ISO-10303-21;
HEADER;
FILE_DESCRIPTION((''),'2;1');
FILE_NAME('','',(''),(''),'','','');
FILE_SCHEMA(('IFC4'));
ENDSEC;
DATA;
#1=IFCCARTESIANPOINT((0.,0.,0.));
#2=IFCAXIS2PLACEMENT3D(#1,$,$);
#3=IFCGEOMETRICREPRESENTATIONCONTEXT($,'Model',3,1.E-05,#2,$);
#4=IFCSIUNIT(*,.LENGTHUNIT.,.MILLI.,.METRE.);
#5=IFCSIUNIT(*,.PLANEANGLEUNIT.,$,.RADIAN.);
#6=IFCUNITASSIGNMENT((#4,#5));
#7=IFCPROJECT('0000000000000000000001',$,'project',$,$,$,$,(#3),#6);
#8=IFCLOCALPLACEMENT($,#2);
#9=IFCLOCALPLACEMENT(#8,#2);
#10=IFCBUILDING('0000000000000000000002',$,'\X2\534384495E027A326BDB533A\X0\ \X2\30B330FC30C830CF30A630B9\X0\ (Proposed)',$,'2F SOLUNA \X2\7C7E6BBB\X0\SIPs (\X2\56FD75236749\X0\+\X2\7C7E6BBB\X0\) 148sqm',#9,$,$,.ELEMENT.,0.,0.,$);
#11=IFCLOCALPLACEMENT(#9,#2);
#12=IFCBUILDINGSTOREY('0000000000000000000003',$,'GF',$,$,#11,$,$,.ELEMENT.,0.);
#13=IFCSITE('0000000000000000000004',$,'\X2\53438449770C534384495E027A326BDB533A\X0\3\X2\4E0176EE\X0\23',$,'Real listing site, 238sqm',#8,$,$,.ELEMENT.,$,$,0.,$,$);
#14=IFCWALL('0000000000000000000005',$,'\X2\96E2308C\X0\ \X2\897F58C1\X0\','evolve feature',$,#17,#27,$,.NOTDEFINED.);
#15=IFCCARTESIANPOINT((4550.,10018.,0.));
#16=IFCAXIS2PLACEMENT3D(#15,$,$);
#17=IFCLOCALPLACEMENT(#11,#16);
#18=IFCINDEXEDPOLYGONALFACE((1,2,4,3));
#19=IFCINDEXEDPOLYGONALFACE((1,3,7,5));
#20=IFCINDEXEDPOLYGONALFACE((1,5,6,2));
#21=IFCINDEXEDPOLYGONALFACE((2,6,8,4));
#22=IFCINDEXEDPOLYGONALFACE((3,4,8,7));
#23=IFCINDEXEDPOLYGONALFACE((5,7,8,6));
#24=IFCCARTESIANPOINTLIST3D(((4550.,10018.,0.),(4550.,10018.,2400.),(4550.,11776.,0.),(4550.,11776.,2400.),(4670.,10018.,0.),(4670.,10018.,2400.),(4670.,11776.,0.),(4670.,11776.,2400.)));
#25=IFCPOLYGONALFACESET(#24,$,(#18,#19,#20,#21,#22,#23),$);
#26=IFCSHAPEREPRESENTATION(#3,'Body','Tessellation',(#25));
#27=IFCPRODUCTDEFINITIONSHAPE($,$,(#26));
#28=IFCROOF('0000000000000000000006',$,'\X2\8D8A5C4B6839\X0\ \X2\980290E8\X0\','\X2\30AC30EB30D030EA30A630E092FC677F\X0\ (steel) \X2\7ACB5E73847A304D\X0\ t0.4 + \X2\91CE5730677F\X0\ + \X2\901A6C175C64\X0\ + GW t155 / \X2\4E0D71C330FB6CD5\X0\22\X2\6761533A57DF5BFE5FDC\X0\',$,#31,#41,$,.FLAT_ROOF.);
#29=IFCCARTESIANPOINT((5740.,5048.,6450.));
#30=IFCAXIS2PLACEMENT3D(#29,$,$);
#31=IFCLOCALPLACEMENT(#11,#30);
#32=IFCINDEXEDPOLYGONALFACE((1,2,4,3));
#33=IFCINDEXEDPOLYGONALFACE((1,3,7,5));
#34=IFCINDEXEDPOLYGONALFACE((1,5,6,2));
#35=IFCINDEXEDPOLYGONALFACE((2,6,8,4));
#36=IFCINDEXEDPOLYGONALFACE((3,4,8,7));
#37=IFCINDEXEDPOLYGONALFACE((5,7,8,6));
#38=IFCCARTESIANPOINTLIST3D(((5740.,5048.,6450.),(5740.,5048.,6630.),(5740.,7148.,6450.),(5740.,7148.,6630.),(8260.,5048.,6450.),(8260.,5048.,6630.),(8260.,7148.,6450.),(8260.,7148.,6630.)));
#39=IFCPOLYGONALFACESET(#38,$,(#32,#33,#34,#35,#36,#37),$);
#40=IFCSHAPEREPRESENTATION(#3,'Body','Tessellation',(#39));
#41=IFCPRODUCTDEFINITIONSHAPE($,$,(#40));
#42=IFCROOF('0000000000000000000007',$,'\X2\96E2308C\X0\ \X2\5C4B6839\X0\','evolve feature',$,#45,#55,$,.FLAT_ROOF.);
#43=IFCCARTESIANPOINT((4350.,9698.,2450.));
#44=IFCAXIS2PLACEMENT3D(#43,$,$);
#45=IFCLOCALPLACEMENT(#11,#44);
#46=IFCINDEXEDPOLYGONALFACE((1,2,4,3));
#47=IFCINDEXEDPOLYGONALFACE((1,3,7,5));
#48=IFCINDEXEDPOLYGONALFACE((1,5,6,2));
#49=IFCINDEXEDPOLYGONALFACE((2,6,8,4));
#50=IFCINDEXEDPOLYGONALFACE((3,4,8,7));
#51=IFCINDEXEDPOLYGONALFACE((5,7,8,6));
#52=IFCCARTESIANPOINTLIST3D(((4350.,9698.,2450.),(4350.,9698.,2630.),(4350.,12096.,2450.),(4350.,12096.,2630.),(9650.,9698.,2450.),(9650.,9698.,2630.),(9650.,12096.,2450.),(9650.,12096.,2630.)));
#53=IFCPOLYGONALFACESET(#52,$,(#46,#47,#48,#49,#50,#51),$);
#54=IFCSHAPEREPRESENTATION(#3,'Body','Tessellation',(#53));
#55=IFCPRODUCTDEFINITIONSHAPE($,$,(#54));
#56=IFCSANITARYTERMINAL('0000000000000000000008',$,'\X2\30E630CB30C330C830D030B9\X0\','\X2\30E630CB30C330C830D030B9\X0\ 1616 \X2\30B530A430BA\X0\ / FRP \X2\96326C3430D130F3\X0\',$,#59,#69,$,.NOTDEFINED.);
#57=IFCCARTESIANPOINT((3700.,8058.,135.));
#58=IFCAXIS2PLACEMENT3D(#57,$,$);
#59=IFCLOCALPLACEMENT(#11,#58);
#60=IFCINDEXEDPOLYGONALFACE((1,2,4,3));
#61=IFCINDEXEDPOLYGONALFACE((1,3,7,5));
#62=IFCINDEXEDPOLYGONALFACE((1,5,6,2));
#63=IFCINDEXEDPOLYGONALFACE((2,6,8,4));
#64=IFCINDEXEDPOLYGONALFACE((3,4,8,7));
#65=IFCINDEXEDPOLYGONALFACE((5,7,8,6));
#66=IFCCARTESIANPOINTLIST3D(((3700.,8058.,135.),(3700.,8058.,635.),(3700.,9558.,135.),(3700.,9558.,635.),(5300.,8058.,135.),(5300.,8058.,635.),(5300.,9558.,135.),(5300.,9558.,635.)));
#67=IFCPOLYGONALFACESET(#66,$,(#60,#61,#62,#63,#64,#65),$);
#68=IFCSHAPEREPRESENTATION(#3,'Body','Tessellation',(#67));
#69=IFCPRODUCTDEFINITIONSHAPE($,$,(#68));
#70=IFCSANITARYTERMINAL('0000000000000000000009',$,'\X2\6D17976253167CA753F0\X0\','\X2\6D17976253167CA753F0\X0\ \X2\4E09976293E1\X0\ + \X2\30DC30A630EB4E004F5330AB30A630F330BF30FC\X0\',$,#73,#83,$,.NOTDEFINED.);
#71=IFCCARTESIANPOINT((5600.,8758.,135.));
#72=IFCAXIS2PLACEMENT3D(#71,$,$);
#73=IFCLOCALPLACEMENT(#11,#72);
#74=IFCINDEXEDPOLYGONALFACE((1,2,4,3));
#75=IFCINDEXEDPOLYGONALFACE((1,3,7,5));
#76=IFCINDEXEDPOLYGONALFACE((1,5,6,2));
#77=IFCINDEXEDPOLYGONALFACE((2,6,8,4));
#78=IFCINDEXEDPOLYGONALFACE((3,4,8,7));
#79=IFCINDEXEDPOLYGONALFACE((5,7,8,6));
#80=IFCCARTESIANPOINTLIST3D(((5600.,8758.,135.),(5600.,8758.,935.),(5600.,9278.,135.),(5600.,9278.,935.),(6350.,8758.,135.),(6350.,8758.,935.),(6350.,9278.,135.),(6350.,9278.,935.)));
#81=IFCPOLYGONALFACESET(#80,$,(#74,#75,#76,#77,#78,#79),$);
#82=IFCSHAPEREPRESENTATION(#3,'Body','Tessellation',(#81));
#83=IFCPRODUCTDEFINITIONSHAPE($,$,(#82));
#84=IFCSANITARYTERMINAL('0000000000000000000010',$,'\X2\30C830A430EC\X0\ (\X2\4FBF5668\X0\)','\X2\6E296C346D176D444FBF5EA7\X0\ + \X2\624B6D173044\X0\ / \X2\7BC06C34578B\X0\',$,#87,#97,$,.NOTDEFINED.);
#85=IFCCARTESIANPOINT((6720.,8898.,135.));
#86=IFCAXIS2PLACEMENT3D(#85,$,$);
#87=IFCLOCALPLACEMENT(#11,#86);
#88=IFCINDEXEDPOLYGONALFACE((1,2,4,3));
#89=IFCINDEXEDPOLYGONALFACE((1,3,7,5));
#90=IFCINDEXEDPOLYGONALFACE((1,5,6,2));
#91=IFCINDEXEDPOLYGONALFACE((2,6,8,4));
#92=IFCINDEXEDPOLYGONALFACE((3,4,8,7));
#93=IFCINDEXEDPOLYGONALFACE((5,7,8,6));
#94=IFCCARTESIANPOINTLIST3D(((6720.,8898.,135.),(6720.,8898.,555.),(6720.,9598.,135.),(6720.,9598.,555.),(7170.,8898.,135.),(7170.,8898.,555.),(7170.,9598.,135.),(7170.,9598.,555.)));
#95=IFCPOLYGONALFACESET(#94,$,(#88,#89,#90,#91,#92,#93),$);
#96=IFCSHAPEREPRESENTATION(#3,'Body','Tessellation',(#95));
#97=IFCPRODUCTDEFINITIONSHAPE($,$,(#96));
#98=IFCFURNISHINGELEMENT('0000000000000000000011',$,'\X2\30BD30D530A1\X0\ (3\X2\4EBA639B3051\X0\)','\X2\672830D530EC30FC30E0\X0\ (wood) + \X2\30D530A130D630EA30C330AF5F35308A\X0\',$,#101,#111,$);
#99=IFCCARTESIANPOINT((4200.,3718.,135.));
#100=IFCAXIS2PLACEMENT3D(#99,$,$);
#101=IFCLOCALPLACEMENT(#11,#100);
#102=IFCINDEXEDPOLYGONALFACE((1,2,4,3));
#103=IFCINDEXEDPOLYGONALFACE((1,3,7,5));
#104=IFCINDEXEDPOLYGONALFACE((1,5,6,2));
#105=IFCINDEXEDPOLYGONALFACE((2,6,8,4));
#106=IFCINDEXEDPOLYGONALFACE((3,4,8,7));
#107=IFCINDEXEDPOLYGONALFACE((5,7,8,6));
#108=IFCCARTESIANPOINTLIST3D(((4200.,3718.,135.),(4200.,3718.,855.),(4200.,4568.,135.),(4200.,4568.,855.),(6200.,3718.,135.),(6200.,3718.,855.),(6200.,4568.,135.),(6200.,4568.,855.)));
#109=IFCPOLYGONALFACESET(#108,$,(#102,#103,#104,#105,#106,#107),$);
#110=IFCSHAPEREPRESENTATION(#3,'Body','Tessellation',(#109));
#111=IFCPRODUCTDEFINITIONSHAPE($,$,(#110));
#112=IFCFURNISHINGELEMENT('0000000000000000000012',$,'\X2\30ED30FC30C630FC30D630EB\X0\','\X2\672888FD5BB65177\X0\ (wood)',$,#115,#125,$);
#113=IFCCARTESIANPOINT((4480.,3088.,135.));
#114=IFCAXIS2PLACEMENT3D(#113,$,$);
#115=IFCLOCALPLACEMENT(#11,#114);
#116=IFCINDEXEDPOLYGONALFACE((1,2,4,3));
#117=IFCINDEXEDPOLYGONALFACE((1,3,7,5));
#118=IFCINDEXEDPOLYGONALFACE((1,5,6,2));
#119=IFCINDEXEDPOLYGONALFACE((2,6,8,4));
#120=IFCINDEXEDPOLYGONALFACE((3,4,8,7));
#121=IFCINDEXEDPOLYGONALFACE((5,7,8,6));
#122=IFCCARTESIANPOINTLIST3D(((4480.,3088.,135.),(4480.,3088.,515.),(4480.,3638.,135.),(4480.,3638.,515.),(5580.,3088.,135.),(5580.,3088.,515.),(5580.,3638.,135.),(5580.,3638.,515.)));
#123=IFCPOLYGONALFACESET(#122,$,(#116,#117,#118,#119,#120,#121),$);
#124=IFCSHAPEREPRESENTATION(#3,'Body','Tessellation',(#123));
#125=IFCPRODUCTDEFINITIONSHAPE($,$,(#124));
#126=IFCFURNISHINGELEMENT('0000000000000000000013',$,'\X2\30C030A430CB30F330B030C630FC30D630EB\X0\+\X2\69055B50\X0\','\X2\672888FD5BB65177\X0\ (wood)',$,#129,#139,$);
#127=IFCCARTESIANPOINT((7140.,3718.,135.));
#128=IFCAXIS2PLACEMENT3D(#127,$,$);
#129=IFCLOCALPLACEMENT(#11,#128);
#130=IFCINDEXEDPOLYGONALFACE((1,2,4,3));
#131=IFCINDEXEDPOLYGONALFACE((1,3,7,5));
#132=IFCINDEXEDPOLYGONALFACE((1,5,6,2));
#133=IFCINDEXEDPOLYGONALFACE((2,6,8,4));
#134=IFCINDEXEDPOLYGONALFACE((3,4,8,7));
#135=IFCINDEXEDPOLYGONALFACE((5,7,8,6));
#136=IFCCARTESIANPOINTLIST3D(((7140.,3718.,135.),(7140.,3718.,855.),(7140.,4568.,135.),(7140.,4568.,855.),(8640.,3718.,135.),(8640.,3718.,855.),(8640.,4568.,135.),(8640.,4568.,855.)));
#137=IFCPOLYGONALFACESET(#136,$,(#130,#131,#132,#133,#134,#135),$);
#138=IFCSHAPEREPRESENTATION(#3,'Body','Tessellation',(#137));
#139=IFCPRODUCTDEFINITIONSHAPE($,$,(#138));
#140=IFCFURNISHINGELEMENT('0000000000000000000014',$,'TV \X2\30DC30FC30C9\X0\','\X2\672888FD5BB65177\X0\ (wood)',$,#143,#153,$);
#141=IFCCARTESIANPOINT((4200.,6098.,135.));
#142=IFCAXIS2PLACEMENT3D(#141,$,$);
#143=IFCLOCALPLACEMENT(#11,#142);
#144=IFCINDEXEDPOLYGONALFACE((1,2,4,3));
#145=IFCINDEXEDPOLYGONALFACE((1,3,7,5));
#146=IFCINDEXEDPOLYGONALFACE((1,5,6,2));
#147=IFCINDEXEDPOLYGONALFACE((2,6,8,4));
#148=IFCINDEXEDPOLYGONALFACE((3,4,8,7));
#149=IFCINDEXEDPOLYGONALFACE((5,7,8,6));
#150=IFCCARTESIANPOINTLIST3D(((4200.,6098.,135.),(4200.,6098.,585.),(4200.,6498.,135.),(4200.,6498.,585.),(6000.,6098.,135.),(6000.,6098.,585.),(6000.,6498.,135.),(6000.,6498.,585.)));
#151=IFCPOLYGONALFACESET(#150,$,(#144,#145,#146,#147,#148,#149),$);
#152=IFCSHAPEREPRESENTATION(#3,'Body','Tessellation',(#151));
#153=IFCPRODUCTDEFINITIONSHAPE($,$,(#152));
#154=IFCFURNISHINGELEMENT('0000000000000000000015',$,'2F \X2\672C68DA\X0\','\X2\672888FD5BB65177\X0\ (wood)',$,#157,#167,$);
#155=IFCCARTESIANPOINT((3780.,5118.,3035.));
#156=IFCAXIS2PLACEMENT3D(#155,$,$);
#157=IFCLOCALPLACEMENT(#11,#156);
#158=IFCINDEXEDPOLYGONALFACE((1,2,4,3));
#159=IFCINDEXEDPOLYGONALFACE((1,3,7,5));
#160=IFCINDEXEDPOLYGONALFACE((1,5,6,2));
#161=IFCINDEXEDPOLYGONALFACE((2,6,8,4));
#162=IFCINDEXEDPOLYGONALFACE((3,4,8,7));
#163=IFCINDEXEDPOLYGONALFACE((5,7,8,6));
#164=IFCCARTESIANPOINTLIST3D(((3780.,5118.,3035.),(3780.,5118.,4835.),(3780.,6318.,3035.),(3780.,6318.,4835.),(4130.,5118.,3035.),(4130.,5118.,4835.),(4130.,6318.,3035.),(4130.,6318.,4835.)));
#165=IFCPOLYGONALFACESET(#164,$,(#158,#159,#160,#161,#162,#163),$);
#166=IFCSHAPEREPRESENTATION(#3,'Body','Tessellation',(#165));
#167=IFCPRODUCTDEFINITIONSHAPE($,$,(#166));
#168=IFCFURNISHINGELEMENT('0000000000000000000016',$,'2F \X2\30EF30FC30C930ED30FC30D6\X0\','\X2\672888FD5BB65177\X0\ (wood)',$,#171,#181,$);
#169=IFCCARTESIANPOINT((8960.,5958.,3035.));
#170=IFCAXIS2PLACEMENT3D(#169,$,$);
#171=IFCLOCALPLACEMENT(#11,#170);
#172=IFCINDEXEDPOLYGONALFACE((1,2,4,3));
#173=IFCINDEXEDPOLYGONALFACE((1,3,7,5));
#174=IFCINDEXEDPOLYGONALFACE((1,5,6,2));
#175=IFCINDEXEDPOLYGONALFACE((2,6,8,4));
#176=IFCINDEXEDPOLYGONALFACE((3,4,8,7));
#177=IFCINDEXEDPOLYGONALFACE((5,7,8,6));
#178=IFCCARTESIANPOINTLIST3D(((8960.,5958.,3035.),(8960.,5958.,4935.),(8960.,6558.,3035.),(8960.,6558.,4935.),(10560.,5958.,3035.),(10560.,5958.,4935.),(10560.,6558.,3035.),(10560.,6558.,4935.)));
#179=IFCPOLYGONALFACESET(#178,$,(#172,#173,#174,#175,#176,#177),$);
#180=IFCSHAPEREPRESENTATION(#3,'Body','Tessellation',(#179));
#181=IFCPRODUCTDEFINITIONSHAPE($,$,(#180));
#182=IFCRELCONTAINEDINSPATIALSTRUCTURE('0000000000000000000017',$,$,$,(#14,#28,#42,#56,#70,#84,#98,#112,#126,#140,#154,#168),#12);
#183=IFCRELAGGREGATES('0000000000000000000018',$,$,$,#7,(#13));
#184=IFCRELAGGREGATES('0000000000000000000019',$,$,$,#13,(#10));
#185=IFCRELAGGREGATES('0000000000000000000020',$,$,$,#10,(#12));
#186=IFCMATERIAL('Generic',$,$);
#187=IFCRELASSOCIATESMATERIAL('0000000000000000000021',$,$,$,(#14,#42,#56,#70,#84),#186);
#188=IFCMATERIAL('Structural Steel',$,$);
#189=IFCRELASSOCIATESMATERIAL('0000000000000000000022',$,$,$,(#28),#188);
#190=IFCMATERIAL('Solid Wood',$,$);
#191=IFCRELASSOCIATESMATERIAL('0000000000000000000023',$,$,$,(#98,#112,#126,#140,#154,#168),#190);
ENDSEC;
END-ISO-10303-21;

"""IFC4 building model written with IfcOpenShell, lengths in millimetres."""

from ifc_helpers import new_model, si_unit, frame, frame_2d, origin, place, context, project, spatial, rectangle, extrude, material, element, save


model = new_model("IFC4")

# Units and contexts
model_context = context("Model", 3, precision=1e-05, world=origin())
ifc_project = project(units=[si_unit("LENGTHUNIT", "METRE", prefix="MILLI"), si_unit("PLANEANGLEUNIT", "RADIAN")], contexts=[model_context])

# Site, building, storey
site_placement = place(None, origin())
site = spatial("IfcSite", under=ifc_project, at=site_placement, Name="千葉県千葉市稲毛区3丁目23", ObjectType="Real listing site, 238sqm", CompositionType="ELEMENT", RefElevation=0.0)
building_placement = place(site_placement, origin())
building = spatial("IfcBuilding", under=site, at=building_placement, Name="千葉市稲毛区 コートハウス (Proposed)", ObjectType="2F SOLUNA 籾殻SIPs (国産杉+籾殻) 148sqm", CompositionType="ELEMENT", ElevationOfRefHeight=0.0, ElevationOfTerrain=0.0)
storey_placement = place(building_placement, origin())
storey = spatial("IfcBuildingStorey", under=building, at=storey_placement, Name="GF", CompositionType="ELEMENT", Elevation=0.0)

# Shared definitions
ifc_material_1 = material(Name="Generic")

# Shared definitions
ifc_material_2 = material(Name="Solid Wood")

# Wall
wall_1_placement = place(storey_placement, frame((4550.0, 10018.0, 0.0)))
element("IfcWall", 1, at=wall_1_placement, inside=storey, material=ifc_material_1, Name="離れ 西壁", Description="evolve feature", PredefinedType="NOTDEFINED", context=model_context, shape_type="SweptSolid", body=[
    extrude(rectangle(XDim=120.0, YDim=1758.0, at=frame_2d((60.0, 879.0))), frame((4550.0, 10018.0, 0.0)), (0.0, 0.0, 1.0), 2400.0),
])

# Roofs
ifc_material_3 = material(Name="Structural Steel")
roof_1_placement = place(storey_placement, frame((5740.0, 5048.0, 6450.0)))
element("IfcRoof", 2, at=roof_1_placement, inside=storey, material=ifc_material_3, Name="越屋根 頂部", Description="ガルバリウム鋼板 (steel) 立平葺き t0.4 + 野地板 + 通気層 + GW t155 / 不燃・法22条区域対応", PredefinedType="FLAT_ROOF", context=model_context, shape_type="SweptSolid", body=[
    extrude(rectangle(XDim=2520.0, YDim=2100.0, at=frame_2d((1260.0, 1050.0))), frame((5740.0, 5048.0, 6450.0)), (0.0, 0.0, 1.0), 180.0),
])
roof_2_placement = place(storey_placement, frame((4350.0, 9698.0, 2450.0)))
element("IfcRoof", 3, at=roof_2_placement, inside=storey, material=ifc_material_1, Name="離れ 屋根", Description="evolve feature", PredefinedType="FLAT_ROOF", context=model_context, shape_type="SweptSolid", body=[
    extrude(rectangle(XDim=5300.0, YDim=2398.0, at=frame_2d((2650.0, 1199.0))), frame((4350.0, 9698.0, 2450.0)), (0.0, 0.0, 1.0), 180.0),
])

# Sanitary terminals
sanitary_terminal_1_placement = place(storey_placement, frame((3700.0, 8058.0, 135.0)))
element("IfcSanitaryTerminal", 4, at=sanitary_terminal_1_placement, inside=storey, material=ifc_material_1, Name="ユニットバス", Description="ユニットバス 1616 サイズ / FRP 防水パン", PredefinedType="NOTDEFINED", context=model_context, shape_type="SweptSolid", body=[
    extrude(rectangle(XDim=1600.0, YDim=1500.0, at=frame_2d((800.0, 750.0))), frame((3700.0, 8058.0, 135.0)), (0.0, 0.0, 1.0), 500.0),
])
sanitary_terminal_2_placement = place(storey_placement, frame((5600.0, 8758.0, 135.0)))
element("IfcSanitaryTerminal", 5, at=sanitary_terminal_2_placement, inside=storey, material=ifc_material_1, Name="洗面化粧台", Description="洗面化粧台 三面鏡 + ボウル一体カウンター", PredefinedType="NOTDEFINED", context=model_context, shape_type="SweptSolid", body=[
    extrude(rectangle(XDim=750.0, YDim=520.0, at=frame_2d((375.0, 260.0))), frame((5600.0, 8758.0, 135.0)), (0.0, 0.0, 1.0), 800.0),
])
sanitary_terminal_3_placement = place(storey_placement, frame((6720.0, 8898.0, 135.0)))
element("IfcSanitaryTerminal", 6, at=sanitary_terminal_3_placement, inside=storey, material=ifc_material_1, Name="トイレ (便器)", Description="温水洗浄便座 + 手洗い / 節水型", PredefinedType="NOTDEFINED", context=model_context, shape_type="SweptSolid", body=[
    extrude(rectangle(XDim=450.0, YDim=700.0, at=frame_2d((225.0, 350.0))), frame((6720.0, 8898.0, 135.0)), (0.0, 0.0, 1.0), 420.0),
])

# Furnishing elements
furnishing_1_placement = place(storey_placement, frame((4200.0, 3718.0, 135.0)))
element("IfcFurnishingElement", 7, at=furnishing_1_placement, inside=storey, material=ifc_material_2, Name="ソファ (3人掛け)", Description="木フレーム (wood) + ファブリック張り", context=model_context, shape_type="SweptSolid", body=[
    extrude(rectangle(XDim=2000.0, YDim=850.0, at=frame_2d((1000.0, 425.0))), frame((4200.0, 3718.0, 135.0)), (0.0, 0.0, 1.0), 720.0),
])
furnishing_2_placement = place(storey_placement, frame((4480.0, 3088.0, 135.0)))
element("IfcFurnishingElement", 8, at=furnishing_2_placement, inside=storey, material=ifc_material_2, Name="ローテーブル", Description="木製家具 (wood)", context=model_context, shape_type="SweptSolid", body=[
    extrude(rectangle(XDim=1100.0, YDim=550.0, at=frame_2d((550.0, 275.0))), frame((4480.0, 3088.0, 135.0)), (0.0, 0.0, 1.0), 380.0),
])
furnishing_3_placement = place(storey_placement, frame((7140.0, 3718.0, 135.0)))
element("IfcFurnishingElement", 9, at=furnishing_3_placement, inside=storey, material=ifc_material_2, Name="ダイニングテーブル+椅子", Description="木製家具 (wood)", context=model_context, shape_type="SweptSolid", body=[
    extrude(rectangle(XDim=1500.0, YDim=850.0, at=frame_2d((750.0, 425.0))), frame((7140.0, 3718.0, 135.0)), (0.0, 0.0, 1.0), 720.0),
])
furnishing_4_placement = place(storey_placement, frame((4200.0, 6098.0, 135.0)))
element("IfcFurnishingElement", 10, at=furnishing_4_placement, inside=storey, material=ifc_material_2, Name="TV ボード", Description="木製家具 (wood)", context=model_context, shape_type="SweptSolid", body=[
    extrude(rectangle(XDim=1800.0, YDim=400.0, at=frame_2d((900.0, 200.0))), frame((4200.0, 6098.0, 135.0)), (0.0, 0.0, 1.0), 450.0),
])
furnishing_5_placement = place(storey_placement, frame((3780.0, 5118.0, 3035.0)))
element("IfcFurnishingElement", 11, at=furnishing_5_placement, inside=storey, material=ifc_material_2, Name="2F 本棚", Description="木製家具 (wood)", context=model_context, shape_type="SweptSolid", body=[
    extrude(rectangle(XDim=350.0, YDim=1200.0, at=frame_2d((175.0, 600.0))), frame((3780.0, 5118.0, 3035.0)), (0.0, 0.0, 1.0), 1800.0),
])
furnishing_6_placement = place(storey_placement, frame((8960.0, 5958.0, 3035.0)))
element("IfcFurnishingElement", 12, at=furnishing_6_placement, inside=storey, material=ifc_material_2, Name="2F ワードローブ", Description="木製家具 (wood)", context=model_context, shape_type="SweptSolid", body=[
    extrude(rectangle(XDim=1600.0, YDim=600.0, at=frame_2d((800.0, 300.0))), frame((8960.0, 5958.0, 3035.0)), (0.0, 0.0, 1.0), 1900.0),
])

save(model, "model.ifc")
